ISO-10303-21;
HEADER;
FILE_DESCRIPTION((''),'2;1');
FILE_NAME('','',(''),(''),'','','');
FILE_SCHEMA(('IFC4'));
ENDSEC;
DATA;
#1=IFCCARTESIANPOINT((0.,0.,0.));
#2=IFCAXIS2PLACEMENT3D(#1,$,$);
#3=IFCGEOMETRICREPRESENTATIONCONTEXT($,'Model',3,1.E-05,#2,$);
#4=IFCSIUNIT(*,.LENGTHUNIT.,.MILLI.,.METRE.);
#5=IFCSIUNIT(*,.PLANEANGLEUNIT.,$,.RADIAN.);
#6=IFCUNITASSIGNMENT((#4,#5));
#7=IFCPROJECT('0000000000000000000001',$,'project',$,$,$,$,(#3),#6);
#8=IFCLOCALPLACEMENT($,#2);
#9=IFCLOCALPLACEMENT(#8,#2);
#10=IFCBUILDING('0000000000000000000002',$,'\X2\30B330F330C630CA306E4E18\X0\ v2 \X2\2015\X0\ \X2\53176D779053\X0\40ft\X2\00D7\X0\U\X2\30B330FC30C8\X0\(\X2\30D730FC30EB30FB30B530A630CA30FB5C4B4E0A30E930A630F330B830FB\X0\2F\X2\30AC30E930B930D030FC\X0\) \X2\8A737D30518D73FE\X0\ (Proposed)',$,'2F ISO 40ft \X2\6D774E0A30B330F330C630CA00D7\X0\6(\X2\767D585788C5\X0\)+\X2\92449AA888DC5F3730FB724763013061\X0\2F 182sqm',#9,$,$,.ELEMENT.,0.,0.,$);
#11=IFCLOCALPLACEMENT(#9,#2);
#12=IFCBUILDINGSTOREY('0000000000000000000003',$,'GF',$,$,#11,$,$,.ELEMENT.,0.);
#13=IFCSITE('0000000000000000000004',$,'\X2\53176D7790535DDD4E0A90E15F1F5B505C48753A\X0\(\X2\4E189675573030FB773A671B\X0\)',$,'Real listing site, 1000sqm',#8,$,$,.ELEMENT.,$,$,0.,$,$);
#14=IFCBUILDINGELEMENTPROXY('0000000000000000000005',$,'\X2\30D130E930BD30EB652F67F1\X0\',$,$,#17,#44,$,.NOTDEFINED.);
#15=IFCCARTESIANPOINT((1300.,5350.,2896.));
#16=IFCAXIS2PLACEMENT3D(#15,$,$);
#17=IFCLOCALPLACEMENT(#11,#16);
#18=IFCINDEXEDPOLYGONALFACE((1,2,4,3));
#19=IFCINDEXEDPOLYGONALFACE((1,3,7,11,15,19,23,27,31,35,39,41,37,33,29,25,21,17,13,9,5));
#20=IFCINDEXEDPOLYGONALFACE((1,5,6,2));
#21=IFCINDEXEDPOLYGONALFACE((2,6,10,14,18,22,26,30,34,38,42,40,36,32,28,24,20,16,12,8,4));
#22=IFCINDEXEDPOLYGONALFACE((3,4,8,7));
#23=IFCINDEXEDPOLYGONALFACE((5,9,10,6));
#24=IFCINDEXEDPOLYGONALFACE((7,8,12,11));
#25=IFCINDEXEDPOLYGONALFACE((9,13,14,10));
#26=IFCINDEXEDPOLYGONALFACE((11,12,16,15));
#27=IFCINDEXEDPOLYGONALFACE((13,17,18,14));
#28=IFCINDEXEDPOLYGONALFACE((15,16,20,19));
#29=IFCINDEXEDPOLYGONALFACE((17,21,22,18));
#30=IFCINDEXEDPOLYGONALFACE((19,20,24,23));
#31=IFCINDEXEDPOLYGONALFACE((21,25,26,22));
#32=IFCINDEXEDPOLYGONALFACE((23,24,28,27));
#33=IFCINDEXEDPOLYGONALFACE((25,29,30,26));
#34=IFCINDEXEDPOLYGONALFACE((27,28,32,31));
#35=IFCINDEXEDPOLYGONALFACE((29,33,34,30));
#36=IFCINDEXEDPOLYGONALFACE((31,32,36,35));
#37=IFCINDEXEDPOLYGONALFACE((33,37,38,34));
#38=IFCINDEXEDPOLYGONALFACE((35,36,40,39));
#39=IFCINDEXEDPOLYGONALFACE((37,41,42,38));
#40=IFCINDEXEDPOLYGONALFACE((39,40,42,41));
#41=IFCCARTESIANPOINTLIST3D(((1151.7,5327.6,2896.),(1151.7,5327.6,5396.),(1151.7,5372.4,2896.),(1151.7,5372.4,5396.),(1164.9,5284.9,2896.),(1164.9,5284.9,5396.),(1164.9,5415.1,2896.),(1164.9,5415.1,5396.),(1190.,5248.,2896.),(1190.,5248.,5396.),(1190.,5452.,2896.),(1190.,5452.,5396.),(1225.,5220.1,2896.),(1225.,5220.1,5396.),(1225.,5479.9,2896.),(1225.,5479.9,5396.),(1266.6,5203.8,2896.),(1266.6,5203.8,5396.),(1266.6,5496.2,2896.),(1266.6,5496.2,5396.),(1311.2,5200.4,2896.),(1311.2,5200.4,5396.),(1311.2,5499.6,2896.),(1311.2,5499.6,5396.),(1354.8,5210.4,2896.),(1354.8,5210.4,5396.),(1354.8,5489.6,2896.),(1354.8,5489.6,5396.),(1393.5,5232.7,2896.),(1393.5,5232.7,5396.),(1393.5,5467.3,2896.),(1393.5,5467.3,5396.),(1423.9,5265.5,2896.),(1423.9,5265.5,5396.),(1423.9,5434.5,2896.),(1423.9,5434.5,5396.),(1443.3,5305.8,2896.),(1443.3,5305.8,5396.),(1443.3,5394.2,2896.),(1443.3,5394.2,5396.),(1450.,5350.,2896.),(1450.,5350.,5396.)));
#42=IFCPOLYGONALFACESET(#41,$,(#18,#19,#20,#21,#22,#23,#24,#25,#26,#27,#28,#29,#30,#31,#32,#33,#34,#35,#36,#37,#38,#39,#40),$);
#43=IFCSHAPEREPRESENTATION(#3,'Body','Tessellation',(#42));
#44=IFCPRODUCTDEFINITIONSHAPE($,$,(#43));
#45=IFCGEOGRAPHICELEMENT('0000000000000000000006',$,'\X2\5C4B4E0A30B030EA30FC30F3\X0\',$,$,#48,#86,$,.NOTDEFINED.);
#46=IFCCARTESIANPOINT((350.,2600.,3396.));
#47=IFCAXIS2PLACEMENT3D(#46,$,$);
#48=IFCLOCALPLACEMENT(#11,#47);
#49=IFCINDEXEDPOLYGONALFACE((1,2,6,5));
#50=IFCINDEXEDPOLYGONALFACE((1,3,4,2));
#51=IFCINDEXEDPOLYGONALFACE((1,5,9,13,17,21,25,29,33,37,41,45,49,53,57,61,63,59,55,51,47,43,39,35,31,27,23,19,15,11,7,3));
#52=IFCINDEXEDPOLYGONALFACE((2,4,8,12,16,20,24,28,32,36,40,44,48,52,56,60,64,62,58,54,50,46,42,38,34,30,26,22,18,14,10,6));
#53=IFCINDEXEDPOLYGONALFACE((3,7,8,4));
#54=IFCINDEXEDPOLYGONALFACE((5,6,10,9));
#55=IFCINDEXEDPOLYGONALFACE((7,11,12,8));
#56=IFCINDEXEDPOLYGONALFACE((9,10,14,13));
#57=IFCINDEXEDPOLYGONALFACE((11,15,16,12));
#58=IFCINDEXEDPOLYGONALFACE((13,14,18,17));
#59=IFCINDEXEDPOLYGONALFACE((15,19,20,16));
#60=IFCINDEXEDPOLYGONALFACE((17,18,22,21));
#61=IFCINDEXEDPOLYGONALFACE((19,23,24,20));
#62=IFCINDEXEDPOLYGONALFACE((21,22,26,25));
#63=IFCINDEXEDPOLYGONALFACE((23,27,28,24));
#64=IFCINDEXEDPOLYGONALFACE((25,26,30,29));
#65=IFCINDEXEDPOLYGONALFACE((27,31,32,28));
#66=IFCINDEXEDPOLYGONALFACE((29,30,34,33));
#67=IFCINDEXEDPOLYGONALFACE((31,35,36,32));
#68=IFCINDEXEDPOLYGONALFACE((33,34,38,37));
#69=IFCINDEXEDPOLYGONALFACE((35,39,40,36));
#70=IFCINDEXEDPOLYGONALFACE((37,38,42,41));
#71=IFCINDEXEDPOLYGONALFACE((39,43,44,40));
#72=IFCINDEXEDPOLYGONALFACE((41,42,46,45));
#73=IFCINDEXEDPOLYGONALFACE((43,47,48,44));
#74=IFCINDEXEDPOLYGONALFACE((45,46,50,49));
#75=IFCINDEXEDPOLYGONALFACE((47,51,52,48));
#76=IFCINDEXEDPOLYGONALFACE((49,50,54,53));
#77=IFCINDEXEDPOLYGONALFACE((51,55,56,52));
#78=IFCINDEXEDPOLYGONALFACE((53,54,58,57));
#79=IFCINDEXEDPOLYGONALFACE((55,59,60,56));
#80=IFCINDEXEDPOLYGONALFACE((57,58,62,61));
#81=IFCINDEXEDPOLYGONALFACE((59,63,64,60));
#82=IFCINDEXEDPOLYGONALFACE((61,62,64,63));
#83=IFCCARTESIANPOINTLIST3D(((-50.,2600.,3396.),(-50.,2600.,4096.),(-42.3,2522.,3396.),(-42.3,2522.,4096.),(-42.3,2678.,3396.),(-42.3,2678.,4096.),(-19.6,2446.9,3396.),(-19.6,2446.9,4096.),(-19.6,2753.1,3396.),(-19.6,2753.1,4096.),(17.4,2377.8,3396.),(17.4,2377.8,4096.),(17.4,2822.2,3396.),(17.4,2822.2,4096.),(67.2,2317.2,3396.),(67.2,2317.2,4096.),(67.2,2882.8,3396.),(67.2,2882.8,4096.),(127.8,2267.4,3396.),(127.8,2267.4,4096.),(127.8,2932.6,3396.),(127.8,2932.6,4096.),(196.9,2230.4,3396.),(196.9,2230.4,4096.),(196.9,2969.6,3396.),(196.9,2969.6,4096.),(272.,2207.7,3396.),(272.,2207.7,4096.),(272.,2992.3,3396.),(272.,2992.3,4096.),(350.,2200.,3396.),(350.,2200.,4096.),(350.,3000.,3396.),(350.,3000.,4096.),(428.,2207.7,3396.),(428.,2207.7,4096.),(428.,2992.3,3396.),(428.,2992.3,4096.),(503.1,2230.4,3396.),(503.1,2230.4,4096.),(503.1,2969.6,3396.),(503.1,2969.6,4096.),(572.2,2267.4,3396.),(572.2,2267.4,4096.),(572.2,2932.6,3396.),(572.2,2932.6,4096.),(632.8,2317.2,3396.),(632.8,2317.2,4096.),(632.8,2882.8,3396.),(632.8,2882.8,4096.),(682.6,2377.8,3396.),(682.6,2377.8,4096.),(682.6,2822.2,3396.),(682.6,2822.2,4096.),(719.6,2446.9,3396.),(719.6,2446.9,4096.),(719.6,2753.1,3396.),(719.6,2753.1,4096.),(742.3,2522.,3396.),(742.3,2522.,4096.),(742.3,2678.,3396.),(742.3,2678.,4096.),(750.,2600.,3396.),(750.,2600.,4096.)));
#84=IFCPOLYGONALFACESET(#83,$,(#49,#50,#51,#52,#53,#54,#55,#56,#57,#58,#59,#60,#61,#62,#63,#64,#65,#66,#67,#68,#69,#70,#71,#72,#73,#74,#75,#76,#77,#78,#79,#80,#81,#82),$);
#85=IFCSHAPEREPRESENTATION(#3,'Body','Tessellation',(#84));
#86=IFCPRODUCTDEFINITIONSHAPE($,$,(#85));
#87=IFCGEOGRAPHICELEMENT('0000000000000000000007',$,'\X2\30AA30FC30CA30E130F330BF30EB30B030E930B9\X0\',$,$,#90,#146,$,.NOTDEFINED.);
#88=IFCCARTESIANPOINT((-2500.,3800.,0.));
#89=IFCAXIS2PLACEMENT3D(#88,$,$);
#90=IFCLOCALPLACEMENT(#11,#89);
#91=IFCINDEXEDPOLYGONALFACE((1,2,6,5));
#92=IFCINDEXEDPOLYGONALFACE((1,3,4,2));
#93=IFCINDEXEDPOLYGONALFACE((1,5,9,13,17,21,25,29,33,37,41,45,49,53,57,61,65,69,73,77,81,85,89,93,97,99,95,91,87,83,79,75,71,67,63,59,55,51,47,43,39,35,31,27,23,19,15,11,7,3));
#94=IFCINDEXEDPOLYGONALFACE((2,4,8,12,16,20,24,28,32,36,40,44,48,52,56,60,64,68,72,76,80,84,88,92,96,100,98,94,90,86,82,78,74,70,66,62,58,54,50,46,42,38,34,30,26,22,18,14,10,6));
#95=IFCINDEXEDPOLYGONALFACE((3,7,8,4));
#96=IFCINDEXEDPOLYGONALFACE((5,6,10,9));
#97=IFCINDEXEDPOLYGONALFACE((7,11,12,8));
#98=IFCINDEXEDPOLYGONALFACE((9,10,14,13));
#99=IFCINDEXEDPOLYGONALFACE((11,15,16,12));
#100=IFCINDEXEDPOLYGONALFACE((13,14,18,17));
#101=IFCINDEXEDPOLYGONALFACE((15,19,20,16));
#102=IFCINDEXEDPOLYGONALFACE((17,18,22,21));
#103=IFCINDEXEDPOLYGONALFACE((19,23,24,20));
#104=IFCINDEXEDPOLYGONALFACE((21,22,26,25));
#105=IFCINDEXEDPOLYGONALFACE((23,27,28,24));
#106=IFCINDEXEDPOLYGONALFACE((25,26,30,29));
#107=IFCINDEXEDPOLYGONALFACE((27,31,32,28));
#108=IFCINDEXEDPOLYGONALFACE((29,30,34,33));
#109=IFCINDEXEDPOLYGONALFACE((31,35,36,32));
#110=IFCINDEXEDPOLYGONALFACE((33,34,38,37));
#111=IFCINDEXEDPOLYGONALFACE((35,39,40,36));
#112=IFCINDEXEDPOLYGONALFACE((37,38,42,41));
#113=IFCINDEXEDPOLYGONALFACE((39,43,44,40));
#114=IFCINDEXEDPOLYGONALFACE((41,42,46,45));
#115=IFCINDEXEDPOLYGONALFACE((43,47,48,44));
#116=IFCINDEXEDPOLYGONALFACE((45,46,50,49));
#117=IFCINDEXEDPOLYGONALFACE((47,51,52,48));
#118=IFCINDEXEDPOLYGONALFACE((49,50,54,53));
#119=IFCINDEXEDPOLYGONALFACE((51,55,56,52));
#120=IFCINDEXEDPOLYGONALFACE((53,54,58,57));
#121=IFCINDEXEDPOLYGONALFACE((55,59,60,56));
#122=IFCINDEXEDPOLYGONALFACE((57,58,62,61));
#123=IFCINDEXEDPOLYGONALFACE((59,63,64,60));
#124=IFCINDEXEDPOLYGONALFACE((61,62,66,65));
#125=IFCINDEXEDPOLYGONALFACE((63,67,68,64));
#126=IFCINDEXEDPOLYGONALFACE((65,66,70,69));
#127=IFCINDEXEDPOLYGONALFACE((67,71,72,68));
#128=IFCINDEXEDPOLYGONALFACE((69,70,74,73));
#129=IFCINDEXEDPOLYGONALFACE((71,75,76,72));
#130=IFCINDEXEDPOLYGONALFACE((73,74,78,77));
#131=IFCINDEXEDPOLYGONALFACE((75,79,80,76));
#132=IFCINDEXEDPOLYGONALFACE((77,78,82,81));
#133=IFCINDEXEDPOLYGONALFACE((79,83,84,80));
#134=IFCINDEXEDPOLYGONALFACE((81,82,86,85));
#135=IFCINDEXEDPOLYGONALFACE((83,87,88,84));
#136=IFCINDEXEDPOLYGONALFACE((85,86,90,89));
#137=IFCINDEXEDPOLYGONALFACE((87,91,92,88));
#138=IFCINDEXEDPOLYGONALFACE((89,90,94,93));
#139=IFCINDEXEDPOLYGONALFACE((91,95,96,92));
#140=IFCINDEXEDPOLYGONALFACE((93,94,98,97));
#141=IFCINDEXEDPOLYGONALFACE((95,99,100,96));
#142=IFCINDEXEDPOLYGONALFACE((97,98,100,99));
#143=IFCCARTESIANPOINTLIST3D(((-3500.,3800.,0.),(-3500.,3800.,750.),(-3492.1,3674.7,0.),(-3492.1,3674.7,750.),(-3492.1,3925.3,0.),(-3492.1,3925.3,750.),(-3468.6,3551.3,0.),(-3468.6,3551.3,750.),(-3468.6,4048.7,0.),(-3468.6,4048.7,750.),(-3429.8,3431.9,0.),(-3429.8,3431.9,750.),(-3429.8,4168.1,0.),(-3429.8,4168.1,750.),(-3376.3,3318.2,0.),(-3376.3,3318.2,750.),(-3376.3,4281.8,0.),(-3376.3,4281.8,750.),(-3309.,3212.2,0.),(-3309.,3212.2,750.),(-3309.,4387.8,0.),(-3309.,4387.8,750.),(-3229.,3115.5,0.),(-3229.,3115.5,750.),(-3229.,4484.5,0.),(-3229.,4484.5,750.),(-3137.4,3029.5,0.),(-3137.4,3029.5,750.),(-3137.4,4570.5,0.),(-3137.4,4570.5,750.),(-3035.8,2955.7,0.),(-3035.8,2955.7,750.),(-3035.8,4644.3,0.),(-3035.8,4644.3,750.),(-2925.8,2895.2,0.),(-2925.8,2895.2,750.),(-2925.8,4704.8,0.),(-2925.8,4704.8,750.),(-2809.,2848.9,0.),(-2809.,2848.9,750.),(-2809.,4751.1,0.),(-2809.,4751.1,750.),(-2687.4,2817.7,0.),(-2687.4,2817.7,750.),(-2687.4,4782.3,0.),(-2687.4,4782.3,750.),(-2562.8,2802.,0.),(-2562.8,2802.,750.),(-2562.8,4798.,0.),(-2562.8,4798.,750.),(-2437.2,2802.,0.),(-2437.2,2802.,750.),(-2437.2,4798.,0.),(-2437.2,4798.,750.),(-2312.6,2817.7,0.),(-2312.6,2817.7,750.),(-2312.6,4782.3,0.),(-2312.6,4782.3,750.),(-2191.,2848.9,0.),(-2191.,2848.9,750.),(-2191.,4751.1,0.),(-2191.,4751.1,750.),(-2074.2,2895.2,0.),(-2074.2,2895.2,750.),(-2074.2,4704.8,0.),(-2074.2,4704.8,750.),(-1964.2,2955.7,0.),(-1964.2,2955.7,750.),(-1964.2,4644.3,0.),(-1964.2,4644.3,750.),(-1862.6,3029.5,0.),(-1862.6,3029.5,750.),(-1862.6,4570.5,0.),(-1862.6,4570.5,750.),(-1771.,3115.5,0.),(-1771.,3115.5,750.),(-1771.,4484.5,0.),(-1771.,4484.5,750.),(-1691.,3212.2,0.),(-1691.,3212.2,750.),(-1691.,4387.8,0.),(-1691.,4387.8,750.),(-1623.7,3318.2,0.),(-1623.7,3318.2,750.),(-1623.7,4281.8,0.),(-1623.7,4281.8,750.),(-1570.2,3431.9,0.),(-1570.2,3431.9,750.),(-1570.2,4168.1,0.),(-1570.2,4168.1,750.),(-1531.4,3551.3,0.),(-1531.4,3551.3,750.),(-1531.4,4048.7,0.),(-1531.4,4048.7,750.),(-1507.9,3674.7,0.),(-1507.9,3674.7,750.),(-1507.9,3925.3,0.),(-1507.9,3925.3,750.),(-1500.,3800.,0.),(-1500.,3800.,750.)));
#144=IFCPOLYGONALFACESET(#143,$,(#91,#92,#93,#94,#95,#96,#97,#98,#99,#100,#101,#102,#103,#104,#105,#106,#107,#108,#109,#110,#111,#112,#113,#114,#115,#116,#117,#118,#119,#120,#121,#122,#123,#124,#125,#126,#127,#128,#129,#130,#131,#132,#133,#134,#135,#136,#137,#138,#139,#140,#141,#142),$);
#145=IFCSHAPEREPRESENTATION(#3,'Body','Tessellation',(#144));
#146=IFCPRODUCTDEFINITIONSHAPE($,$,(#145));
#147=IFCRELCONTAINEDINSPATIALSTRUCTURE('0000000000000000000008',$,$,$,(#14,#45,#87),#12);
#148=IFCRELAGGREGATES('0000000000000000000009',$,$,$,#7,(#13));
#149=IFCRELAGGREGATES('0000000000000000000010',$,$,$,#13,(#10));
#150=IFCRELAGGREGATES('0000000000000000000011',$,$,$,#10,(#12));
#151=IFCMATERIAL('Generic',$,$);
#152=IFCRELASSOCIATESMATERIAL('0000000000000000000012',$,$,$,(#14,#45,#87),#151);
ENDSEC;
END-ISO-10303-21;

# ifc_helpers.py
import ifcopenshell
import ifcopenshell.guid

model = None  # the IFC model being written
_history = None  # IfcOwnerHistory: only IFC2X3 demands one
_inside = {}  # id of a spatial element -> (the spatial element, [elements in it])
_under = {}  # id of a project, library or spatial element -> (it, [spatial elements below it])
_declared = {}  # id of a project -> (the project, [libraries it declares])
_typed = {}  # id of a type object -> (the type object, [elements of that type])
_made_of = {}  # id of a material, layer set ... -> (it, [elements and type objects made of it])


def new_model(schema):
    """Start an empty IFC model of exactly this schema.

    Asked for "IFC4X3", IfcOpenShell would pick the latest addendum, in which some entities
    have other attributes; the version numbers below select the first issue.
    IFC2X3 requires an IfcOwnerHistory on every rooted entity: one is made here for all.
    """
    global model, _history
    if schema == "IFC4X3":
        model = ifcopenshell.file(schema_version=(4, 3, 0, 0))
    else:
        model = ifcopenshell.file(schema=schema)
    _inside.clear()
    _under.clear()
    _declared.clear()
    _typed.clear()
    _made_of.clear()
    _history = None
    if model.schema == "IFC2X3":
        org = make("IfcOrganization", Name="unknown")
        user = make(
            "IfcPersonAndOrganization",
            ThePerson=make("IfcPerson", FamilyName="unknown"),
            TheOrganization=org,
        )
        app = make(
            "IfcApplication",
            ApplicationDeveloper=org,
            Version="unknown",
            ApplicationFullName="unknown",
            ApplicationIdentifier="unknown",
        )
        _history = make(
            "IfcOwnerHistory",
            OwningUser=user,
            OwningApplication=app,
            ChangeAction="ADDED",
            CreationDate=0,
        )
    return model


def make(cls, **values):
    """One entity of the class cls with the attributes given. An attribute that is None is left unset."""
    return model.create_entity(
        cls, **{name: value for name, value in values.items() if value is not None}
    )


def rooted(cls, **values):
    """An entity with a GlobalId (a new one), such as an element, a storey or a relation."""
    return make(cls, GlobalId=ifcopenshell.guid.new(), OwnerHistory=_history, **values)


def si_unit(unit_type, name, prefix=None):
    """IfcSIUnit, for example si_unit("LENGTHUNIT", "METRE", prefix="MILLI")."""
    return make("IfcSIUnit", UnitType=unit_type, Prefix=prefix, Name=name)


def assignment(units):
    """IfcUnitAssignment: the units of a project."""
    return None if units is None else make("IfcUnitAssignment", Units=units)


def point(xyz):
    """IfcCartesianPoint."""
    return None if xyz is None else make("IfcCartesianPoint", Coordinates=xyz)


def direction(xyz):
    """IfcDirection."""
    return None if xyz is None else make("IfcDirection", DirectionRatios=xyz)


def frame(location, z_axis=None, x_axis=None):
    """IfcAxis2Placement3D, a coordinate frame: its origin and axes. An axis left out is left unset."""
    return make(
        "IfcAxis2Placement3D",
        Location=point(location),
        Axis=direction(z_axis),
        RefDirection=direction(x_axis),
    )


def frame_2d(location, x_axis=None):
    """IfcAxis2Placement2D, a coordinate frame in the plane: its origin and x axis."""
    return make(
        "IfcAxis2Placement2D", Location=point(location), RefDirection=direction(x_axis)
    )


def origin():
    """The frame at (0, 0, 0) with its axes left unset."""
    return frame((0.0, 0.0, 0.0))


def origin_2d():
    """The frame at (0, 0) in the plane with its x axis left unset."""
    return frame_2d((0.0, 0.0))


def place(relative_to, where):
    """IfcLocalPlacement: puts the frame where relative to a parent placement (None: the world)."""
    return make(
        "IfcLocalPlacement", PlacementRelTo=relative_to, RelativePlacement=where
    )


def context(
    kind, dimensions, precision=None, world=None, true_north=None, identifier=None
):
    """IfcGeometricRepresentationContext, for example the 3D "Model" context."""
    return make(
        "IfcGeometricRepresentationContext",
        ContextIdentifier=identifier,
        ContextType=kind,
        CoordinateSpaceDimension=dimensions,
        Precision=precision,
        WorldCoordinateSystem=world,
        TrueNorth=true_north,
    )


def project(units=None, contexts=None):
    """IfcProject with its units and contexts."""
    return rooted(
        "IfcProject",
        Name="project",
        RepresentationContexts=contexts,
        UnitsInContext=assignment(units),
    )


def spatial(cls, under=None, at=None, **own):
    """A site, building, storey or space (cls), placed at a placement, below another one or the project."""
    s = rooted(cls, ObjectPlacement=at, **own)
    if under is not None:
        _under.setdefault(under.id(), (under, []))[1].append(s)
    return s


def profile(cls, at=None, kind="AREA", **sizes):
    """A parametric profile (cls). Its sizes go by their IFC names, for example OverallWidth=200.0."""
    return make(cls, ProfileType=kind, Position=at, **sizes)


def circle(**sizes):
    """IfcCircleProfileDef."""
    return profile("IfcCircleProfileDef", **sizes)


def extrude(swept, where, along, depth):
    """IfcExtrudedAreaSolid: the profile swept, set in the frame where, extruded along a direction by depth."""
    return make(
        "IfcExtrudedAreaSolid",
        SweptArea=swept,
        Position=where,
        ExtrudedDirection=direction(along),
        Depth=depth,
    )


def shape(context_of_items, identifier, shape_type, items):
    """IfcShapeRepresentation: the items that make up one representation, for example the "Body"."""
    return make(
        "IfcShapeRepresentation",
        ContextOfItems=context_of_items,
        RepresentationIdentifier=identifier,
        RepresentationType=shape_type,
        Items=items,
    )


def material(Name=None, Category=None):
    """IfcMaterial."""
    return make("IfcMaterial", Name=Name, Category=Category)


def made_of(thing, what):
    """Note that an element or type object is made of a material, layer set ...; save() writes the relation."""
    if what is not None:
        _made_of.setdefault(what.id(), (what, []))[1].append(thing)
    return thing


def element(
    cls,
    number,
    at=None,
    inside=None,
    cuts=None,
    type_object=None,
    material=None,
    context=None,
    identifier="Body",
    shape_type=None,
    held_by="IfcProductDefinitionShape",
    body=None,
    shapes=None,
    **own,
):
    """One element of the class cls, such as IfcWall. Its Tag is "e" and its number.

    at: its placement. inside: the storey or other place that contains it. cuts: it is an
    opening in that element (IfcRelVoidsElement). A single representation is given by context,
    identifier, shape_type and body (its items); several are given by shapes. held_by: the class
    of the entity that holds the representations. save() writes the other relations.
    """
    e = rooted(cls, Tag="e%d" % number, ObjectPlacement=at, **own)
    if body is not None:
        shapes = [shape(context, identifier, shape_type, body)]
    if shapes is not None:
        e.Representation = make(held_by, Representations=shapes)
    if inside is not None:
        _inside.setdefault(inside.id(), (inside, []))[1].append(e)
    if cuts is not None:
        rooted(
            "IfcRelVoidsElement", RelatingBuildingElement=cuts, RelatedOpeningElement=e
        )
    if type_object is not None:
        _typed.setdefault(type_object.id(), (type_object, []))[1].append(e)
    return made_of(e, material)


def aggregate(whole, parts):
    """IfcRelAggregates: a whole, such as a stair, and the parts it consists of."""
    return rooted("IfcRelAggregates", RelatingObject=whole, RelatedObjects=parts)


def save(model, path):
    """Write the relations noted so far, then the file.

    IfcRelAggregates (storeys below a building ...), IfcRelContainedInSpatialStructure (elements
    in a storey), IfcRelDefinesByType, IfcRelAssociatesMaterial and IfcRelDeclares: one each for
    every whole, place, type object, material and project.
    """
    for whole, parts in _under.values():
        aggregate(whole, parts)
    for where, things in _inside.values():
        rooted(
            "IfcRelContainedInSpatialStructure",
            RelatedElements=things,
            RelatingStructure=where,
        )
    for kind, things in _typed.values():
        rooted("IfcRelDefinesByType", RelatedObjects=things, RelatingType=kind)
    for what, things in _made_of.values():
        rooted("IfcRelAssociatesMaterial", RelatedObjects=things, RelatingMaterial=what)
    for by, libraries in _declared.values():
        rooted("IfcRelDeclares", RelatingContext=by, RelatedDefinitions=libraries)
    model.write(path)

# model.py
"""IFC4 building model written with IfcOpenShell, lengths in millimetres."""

from ifc_helpers import new_model, si_unit, frame, origin, origin_2d, place, context, project, spatial, circle, extrude, material, element, save


model = new_model("IFC4")

# Units and contexts
model_context = context("Model", 3, precision=1e-05, world=origin())
ifc_project = project(units=[si_unit("LENGTHUNIT", "METRE", prefix="MILLI"), si_unit("PLANEANGLEUNIT", "RADIAN")], contexts=[model_context])

# Site, building, storey
site_placement = place(None, origin())
site = spatial("IfcSite", under=ifc_project, at=site_placement, Name="北海道川上郡弟子屈町(丘陵地・眺望)", ObjectType="Real listing site, 1000sqm", CompositionType="ELEMENT", RefElevation=0.0)
building_placement = place(site_placement, origin())
building = spatial("IfcBuilding", under=site, at=building_placement, Name="コンテナの丘 v2 ― 北海道40ft×Uコート(プール・サウナ・屋上ラウンジ・2Fガラスバー) 詳細再現 (Proposed)", ObjectType="2F ISO 40ft 海上コンテナ×6(白塗装)+鉄骨補強・片持ち2F 182sqm", CompositionType="ELEMENT", ElevationOfRefHeight=0.0, ElevationOfTerrain=0.0)
storey_placement = place(building_placement, origin())
storey = spatial("IfcBuildingStorey", under=building, at=storey_placement, Name="GF", CompositionType="ELEMENT", Elevation=0.0)

# Shared definitions
ifc_material = material(Name="Generic")

# Building element proxy
proxy_1_placement = place(storey_placement, frame((1300.0, 5350.0, 2896.0)))
element("IfcBuildingElementProxy", 1, at=proxy_1_placement, inside=storey, material=ifc_material, Name="パラソル支柱", PredefinedType="NOTDEFINED", context=model_context, shape_type="SweptSolid", body=[
    extrude(circle(Radius=150.0, at=origin_2d()), frame((1300.0, 5350.0, 2896.0)), (0.0, 0.0, 1.0), 2500.0),
])

# Geographic elements
geographic_element_1_placement = place(storey_placement, frame((350.0, 2600.0, 3396.0)))
element("IfcGeographicElement", 2, at=geographic_element_1_placement, inside=storey, material=ifc_material, Name="屋上グリーン", PredefinedType="NOTDEFINED", context=model_context, shape_type="SweptSolid", body=[
    extrude(circle(Radius=400.0, at=origin_2d()), frame((350.0, 2600.0, 3396.0)), (0.0, 0.0, 1.0), 700.0),
])
geographic_element_2_placement = place(storey_placement, frame((-2500.0, 3800.0, 0.0)))
element("IfcGeographicElement", 3, at=geographic_element_2_placement, inside=storey, material=ifc_material, Name="オーナメンタルグラス", PredefinedType="NOTDEFINED", context=model_context, shape_type="SweptSolid", body=[
    extrude(circle(Radius=1000.0, at=origin_2d()), frame((-2500.0, 3800.0, 0.0)), (0.0, 0.0, 1.0), 750.0),
])

save(model, "model.ifc")
